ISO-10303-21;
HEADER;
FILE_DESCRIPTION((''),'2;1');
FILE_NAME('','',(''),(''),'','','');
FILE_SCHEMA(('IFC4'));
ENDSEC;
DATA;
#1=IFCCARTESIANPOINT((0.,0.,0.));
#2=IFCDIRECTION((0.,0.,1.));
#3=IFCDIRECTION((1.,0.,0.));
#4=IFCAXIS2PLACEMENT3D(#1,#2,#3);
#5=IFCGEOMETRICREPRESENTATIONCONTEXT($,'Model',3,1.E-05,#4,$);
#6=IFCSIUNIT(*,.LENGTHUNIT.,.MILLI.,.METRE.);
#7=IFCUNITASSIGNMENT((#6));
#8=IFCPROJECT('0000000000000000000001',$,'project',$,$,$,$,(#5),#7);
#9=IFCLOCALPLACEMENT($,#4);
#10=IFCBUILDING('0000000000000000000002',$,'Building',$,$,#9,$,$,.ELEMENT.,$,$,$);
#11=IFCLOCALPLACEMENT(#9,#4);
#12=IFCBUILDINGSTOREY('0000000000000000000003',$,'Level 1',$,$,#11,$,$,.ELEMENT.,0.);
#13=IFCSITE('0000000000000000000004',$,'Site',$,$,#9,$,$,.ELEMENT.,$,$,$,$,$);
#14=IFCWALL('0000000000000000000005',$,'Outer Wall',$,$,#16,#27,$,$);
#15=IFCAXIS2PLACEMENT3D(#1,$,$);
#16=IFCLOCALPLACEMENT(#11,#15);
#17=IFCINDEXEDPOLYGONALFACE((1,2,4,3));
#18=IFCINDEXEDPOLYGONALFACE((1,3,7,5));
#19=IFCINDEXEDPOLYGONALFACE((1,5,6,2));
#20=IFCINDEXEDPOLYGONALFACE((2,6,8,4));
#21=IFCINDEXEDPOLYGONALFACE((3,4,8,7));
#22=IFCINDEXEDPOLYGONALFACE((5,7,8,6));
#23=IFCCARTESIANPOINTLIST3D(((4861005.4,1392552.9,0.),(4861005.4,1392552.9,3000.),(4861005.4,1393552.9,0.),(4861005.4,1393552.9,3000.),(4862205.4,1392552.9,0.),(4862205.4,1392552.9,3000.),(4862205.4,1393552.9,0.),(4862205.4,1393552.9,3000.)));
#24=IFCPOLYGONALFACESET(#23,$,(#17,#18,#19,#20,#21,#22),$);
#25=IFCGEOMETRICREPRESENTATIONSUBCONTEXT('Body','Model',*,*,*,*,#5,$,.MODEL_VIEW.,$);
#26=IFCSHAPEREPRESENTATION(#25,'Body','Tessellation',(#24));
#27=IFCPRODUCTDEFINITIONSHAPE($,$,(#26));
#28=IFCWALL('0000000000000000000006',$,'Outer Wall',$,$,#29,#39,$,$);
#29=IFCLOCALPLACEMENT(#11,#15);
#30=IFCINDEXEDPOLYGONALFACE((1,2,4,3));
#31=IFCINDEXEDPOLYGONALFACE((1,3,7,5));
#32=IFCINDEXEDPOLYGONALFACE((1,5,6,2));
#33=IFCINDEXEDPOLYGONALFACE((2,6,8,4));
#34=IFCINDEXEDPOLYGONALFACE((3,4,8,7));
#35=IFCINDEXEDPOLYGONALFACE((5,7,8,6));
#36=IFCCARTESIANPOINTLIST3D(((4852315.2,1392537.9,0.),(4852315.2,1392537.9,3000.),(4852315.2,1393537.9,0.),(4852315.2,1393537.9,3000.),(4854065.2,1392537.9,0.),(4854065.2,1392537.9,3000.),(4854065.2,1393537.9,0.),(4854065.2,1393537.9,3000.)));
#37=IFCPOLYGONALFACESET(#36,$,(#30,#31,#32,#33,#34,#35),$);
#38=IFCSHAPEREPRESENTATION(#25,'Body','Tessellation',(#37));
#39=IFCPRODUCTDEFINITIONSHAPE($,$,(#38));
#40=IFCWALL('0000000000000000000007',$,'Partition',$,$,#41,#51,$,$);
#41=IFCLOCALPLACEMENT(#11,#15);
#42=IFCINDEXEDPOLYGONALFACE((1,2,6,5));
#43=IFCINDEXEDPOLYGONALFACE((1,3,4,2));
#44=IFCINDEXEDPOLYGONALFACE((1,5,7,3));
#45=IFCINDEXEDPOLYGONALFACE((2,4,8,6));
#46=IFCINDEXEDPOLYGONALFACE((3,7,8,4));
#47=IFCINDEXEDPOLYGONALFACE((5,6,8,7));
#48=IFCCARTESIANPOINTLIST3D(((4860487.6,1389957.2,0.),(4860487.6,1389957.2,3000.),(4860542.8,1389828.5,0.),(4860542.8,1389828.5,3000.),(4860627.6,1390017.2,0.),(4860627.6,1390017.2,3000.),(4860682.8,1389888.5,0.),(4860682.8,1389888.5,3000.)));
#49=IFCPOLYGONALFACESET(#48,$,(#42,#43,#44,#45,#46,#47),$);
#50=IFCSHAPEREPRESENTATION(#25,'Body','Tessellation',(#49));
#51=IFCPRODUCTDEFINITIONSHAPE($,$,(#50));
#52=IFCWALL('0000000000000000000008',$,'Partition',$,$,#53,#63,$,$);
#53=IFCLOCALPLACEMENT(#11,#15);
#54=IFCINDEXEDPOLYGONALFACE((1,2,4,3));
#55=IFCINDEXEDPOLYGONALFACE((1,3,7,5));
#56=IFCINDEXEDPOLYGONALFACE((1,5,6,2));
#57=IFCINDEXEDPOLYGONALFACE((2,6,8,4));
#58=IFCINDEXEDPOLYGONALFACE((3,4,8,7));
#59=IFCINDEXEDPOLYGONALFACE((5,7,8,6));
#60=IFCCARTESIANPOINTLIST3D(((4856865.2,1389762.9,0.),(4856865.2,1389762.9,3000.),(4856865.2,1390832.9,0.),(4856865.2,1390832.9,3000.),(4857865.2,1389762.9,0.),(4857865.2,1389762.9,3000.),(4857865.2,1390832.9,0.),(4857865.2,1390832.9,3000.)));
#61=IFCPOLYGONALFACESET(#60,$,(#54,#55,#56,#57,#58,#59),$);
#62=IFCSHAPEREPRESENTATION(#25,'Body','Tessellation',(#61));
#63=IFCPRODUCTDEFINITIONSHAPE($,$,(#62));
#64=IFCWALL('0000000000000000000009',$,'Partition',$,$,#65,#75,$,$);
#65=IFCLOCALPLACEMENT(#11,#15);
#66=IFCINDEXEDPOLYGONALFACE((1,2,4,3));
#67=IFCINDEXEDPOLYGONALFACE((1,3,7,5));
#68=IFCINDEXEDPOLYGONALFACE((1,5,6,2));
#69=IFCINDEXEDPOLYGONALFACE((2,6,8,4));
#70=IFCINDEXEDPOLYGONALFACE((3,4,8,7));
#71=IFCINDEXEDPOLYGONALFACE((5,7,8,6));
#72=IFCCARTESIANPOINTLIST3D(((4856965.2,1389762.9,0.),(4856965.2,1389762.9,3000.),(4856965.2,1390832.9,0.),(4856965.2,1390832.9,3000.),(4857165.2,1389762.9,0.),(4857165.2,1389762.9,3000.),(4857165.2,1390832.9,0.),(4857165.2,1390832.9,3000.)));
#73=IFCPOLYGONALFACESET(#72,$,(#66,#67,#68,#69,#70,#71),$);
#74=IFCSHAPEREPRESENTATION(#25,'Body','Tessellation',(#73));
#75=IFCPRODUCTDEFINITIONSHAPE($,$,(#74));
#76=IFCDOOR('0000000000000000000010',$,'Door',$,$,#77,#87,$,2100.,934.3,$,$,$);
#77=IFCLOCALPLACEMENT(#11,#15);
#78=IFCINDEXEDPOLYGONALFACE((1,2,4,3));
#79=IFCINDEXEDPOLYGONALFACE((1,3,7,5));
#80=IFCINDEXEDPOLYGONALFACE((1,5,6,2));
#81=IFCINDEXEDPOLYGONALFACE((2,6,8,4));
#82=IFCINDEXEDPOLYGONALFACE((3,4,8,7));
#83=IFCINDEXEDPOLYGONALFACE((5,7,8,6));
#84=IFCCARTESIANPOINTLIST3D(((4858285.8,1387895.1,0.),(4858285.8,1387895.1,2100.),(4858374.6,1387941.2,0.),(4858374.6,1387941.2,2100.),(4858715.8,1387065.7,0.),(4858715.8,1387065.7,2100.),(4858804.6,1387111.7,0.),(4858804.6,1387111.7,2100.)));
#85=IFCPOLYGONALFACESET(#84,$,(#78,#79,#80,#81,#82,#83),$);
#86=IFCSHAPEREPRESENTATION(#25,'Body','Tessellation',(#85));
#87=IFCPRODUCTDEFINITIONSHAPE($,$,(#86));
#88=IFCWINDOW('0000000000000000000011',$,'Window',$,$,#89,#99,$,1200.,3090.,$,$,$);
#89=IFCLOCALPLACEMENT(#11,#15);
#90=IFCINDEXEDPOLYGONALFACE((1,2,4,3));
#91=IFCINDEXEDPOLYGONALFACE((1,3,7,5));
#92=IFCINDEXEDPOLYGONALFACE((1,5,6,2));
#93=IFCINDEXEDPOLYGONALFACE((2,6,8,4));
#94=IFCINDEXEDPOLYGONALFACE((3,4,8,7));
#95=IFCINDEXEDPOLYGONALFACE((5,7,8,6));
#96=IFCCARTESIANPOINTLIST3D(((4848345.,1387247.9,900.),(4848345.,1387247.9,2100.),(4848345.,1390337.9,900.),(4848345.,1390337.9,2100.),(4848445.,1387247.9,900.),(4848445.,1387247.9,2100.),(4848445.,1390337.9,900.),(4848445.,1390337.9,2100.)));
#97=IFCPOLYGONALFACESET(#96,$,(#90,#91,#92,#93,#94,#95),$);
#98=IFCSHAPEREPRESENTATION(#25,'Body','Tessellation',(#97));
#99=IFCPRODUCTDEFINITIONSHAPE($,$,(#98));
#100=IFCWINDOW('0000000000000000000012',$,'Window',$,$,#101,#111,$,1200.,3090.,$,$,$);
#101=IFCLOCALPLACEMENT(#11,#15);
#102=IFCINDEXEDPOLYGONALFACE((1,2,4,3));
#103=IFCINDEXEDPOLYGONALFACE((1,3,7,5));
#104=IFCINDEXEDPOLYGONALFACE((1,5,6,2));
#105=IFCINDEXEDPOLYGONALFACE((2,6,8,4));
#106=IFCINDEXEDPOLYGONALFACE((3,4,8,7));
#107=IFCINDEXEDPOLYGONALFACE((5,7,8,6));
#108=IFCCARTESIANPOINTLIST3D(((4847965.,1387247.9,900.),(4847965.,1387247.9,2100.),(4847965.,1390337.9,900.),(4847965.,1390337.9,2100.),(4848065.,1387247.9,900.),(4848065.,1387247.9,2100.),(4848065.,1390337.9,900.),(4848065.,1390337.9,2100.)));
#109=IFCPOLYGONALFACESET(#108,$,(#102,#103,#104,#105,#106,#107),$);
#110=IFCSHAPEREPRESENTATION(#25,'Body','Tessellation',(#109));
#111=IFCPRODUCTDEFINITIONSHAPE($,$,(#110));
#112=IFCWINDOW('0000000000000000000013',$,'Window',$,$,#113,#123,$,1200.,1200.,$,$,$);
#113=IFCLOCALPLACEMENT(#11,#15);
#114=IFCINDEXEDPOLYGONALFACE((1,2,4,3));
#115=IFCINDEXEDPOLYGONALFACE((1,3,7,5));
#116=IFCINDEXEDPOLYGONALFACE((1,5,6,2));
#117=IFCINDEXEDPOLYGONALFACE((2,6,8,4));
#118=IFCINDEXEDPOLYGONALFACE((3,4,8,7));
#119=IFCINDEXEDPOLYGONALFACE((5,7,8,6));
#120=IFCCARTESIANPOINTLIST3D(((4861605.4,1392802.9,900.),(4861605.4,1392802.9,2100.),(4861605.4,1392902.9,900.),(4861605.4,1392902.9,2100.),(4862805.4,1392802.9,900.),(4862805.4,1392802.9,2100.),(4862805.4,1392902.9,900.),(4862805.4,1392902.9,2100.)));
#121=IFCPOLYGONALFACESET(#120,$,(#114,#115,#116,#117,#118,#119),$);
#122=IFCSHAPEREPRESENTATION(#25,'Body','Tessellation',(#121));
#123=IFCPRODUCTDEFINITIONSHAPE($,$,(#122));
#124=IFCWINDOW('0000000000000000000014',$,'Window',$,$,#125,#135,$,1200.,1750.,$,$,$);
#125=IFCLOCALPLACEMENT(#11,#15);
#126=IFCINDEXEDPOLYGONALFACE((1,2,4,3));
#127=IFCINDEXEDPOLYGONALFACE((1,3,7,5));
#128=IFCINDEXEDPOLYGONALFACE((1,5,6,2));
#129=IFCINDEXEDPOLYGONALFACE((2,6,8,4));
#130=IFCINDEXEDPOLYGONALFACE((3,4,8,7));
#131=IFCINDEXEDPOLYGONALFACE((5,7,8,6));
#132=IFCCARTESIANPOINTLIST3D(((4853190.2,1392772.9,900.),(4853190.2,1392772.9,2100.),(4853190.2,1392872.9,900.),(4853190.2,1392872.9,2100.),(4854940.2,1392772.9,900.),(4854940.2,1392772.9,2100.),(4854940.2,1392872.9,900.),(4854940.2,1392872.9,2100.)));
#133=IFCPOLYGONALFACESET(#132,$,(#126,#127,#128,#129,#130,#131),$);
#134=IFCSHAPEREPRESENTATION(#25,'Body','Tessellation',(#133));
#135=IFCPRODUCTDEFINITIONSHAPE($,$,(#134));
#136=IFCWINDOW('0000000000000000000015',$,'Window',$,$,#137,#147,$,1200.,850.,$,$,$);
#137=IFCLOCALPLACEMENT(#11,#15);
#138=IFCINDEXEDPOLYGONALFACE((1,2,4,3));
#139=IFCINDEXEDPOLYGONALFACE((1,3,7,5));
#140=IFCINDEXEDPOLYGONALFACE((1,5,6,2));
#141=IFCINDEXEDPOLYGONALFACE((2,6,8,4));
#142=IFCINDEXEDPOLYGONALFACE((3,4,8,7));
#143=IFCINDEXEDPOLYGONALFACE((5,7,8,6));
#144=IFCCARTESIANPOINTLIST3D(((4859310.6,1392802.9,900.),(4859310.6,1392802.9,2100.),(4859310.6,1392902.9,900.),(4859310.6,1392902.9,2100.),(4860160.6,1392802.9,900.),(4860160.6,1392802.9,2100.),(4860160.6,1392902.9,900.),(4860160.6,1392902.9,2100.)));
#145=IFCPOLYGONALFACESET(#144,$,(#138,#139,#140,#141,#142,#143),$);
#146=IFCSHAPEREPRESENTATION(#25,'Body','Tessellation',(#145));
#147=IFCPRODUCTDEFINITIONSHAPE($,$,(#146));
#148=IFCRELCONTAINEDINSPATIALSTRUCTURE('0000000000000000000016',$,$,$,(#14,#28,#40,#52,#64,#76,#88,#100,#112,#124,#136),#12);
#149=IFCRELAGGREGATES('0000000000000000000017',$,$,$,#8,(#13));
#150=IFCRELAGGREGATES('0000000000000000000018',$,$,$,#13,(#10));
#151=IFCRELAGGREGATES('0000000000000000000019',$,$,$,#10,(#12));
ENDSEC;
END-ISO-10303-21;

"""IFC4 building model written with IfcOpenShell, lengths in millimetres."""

from ifc_helpers import new_model, si_unit, frame, frame_2d, origin_with_axes, place, context, subcontext, project, spatial, rectangle, extrude, element, save


model = new_model("IFC4")

# Units and contexts
model_context = context("Model", 3, precision=1e-05, world=origin_with_axes())
body_context = subcontext(model_context, "Body", "Model", "MODEL_VIEW")
ifc_project = project(units=[si_unit("LENGTHUNIT", "METRE", prefix="MILLI")], contexts=[model_context])

# Site, building, storey
placement = place(None, origin_with_axes())
site = spatial("IfcSite", under=ifc_project, at=placement, Name="Site", CompositionType="ELEMENT")
building = spatial("IfcBuilding", under=site, at=placement, Name="Building", CompositionType="ELEMENT")
storey_placement = place(placement, origin_with_axes())
storey = spatial("IfcBuildingStorey", under=building, at=storey_placement, Name="Level 1", CompositionType="ELEMENT", Elevation=0.0)

# Walls
wall_1_placement = place(placement, frame((4861005.4, 1393052.9, 0.0), z_axis=(0.0, 0.0, 1.0), x_axis=(1.0, 0.0, 0.0)))
element("IfcWall", 1, at=wall_1_placement, inside=storey, Name="Outer Wall", context=body_context, shape_type="SweptSolid", body=[
    extrude(rectangle(XDim=1200.0, YDim=1000.0, at=frame_2d((600.0, 0.0), x_axis=(1.0, 0.0))), origin_with_axes(), (0.0, 0.0, 1.0), 3000.0),
])
wall_2_placement = place(placement, frame((4852315.2, 1393037.9, 0.0), z_axis=(0.0, 0.0, 1.0), x_axis=(1.0, 0.0, 0.0)))
element("IfcWall", 2, at=wall_2_placement, inside=storey, Name="Outer Wall", context=body_context, shape_type="SweptSolid", body=[
    extrude(rectangle(XDim=1750.0, YDim=1000.0, at=frame_2d((875.0, 0.0), x_axis=(1.0, 0.0))), origin_with_axes(), (0.0, 0.0, 1.0), 3000.0),
])
wall_3_placement = place(placement, frame((4860515.2, 1389892.9, 0.0), z_axis=(0.0, 0.0, 1.0), x_axis=(0.919145, 0.393919, 0.0)))
element("IfcWall", 3, at=wall_3_placement, inside=storey, Name="Partition", context=body_context, shape_type="SweptSolid", body=[
    extrude(rectangle(XDim=152.3, YDim=140.0, at=frame_2d((76.2, 0.0), x_axis=(1.0, 0.0))), origin_with_axes(), (0.0, 0.0, 1.0), 3000.0),
])
wall_4_placement = place(placement, frame((4857365.2, 1390832.9, 0.0), z_axis=(0.0, 0.0, 1.0), x_axis=(0.0, -1.0, 0.0)))
element("IfcWall", 4, at=wall_4_placement, inside=storey, Name="Partition", context=body_context, shape_type="SweptSolid", body=[
    extrude(rectangle(XDim=1070.0, YDim=1000.0, at=frame_2d((535.0, 0.0), x_axis=(1.0, 0.0))), origin_with_axes(), (0.0, 0.0, 1.0), 3000.0),
])
wall_5_placement = place(placement, frame((4857065.2, 1390832.9, 0.0), z_axis=(0.0, 0.0, 1.0), x_axis=(0.0, -1.0, 0.0)))
element("IfcWall", 5, at=wall_5_placement, inside=storey, Name="Partition", context=body_context, shape_type="SweptSolid", body=[
    extrude(rectangle(XDim=1070.0, YDim=200.0, at=frame_2d((535.0, 0.0), x_axis=(1.0, 0.0))), origin_with_axes(), (0.0, 0.0, 1.0), 3000.0),
])

# Door
door_placement = place(placement, frame((4858330.2, 1387918.2, 0.0), z_axis=(0.0, 0.0, 1.0), x_axis=(0.460257, -0.887786, 0.0)))
element("IfcDoor", 6, at=door_placement, inside=storey, Name="Door", OverallHeight=2100.0, OverallWidth=934.3, context=body_context, shape_type="SweptSolid", body=[
    extrude(rectangle(XDim=934.3, YDim=100.0, at=frame_2d((467.1, 0.0), x_axis=(1.0, 0.0))), origin_with_axes(), (0.0, 0.0, 1.0), 2100.0),
])

# Windows
for number, where, z_axis, x_axis, name in (
    (7, (4848395.0, 1390337.9, 900.0), (0.0, 0.0, 1.0), (0.0, -1.0, 0.0), "Window"),
    (8, (4848015.0, 1390337.9, 900.0), (0.0, 0.0, 1.0), (0.0, -1.0, 0.0), "Window"),
):
    element("IfcWindow", number, at=place(placement, frame(where, z_axis=z_axis, x_axis=x_axis)), inside=storey, Name=name, OverallHeight=1200.0, OverallWidth=3090.0, context=body_context, shape_type="SweptSolid", body=[
        extrude(rectangle(XDim=3090.0, YDim=100.0, at=frame_2d((1545.0, 0.0), x_axis=(1.0, 0.0))), origin_with_axes(), (0.0, 0.0, 1.0), 1200.0),
    ])
window_1_placement = place(placement, frame((4861605.4, 1392852.9, 900.0), z_axis=(0.0, 0.0, 1.0), x_axis=(1.0, 0.0, 0.0)))
element("IfcWindow", 9, at=window_1_placement, inside=storey, Name="Window", OverallHeight=1200.0, OverallWidth=1200.0, context=body_context, shape_type="SweptSolid", body=[
    extrude(rectangle(XDim=1200.0, YDim=100.0, at=frame_2d((600.0, 0.0), x_axis=(1.0, 0.0))), origin_with_axes(), (0.0, 0.0, 1.0), 1200.0),
])
window_2_placement = place(placement, frame((4853190.2, 1392822.9, 900.0), z_axis=(0.0, 0.0, 1.0), x_axis=(1.0, 0.0, 0.0)))
element("IfcWindow", 10, at=window_2_placement, inside=storey, Name="Window", OverallHeight=1200.0, OverallWidth=1750.0, context=body_context, shape_type="SweptSolid", body=[
    extrude(rectangle(XDim=1750.0, YDim=100.0, at=frame_2d((875.0, 0.0), x_axis=(1.0, 0.0))), origin_with_axes(), (0.0, 0.0, 1.0), 1200.0),
])
window_3_placement = place(placement, frame((4859310.6, 1392852.9, 900.0), z_axis=(0.0, 0.0, 1.0), x_axis=(1.0, 0.0, 0.0)))
element("IfcWindow", 11, at=window_3_placement, inside=storey, Name="Window", OverallHeight=1200.0, OverallWidth=850.0, context=body_context, shape_type="SweptSolid", body=[
    extrude(rectangle(XDim=850.0, YDim=100.0, at=frame_2d((425.0, 0.0), x_axis=(1.0, 0.0))), origin_with_axes(), (0.0, 0.0, 1.0), 1200.0),
])

save(model, "model.ifc")
